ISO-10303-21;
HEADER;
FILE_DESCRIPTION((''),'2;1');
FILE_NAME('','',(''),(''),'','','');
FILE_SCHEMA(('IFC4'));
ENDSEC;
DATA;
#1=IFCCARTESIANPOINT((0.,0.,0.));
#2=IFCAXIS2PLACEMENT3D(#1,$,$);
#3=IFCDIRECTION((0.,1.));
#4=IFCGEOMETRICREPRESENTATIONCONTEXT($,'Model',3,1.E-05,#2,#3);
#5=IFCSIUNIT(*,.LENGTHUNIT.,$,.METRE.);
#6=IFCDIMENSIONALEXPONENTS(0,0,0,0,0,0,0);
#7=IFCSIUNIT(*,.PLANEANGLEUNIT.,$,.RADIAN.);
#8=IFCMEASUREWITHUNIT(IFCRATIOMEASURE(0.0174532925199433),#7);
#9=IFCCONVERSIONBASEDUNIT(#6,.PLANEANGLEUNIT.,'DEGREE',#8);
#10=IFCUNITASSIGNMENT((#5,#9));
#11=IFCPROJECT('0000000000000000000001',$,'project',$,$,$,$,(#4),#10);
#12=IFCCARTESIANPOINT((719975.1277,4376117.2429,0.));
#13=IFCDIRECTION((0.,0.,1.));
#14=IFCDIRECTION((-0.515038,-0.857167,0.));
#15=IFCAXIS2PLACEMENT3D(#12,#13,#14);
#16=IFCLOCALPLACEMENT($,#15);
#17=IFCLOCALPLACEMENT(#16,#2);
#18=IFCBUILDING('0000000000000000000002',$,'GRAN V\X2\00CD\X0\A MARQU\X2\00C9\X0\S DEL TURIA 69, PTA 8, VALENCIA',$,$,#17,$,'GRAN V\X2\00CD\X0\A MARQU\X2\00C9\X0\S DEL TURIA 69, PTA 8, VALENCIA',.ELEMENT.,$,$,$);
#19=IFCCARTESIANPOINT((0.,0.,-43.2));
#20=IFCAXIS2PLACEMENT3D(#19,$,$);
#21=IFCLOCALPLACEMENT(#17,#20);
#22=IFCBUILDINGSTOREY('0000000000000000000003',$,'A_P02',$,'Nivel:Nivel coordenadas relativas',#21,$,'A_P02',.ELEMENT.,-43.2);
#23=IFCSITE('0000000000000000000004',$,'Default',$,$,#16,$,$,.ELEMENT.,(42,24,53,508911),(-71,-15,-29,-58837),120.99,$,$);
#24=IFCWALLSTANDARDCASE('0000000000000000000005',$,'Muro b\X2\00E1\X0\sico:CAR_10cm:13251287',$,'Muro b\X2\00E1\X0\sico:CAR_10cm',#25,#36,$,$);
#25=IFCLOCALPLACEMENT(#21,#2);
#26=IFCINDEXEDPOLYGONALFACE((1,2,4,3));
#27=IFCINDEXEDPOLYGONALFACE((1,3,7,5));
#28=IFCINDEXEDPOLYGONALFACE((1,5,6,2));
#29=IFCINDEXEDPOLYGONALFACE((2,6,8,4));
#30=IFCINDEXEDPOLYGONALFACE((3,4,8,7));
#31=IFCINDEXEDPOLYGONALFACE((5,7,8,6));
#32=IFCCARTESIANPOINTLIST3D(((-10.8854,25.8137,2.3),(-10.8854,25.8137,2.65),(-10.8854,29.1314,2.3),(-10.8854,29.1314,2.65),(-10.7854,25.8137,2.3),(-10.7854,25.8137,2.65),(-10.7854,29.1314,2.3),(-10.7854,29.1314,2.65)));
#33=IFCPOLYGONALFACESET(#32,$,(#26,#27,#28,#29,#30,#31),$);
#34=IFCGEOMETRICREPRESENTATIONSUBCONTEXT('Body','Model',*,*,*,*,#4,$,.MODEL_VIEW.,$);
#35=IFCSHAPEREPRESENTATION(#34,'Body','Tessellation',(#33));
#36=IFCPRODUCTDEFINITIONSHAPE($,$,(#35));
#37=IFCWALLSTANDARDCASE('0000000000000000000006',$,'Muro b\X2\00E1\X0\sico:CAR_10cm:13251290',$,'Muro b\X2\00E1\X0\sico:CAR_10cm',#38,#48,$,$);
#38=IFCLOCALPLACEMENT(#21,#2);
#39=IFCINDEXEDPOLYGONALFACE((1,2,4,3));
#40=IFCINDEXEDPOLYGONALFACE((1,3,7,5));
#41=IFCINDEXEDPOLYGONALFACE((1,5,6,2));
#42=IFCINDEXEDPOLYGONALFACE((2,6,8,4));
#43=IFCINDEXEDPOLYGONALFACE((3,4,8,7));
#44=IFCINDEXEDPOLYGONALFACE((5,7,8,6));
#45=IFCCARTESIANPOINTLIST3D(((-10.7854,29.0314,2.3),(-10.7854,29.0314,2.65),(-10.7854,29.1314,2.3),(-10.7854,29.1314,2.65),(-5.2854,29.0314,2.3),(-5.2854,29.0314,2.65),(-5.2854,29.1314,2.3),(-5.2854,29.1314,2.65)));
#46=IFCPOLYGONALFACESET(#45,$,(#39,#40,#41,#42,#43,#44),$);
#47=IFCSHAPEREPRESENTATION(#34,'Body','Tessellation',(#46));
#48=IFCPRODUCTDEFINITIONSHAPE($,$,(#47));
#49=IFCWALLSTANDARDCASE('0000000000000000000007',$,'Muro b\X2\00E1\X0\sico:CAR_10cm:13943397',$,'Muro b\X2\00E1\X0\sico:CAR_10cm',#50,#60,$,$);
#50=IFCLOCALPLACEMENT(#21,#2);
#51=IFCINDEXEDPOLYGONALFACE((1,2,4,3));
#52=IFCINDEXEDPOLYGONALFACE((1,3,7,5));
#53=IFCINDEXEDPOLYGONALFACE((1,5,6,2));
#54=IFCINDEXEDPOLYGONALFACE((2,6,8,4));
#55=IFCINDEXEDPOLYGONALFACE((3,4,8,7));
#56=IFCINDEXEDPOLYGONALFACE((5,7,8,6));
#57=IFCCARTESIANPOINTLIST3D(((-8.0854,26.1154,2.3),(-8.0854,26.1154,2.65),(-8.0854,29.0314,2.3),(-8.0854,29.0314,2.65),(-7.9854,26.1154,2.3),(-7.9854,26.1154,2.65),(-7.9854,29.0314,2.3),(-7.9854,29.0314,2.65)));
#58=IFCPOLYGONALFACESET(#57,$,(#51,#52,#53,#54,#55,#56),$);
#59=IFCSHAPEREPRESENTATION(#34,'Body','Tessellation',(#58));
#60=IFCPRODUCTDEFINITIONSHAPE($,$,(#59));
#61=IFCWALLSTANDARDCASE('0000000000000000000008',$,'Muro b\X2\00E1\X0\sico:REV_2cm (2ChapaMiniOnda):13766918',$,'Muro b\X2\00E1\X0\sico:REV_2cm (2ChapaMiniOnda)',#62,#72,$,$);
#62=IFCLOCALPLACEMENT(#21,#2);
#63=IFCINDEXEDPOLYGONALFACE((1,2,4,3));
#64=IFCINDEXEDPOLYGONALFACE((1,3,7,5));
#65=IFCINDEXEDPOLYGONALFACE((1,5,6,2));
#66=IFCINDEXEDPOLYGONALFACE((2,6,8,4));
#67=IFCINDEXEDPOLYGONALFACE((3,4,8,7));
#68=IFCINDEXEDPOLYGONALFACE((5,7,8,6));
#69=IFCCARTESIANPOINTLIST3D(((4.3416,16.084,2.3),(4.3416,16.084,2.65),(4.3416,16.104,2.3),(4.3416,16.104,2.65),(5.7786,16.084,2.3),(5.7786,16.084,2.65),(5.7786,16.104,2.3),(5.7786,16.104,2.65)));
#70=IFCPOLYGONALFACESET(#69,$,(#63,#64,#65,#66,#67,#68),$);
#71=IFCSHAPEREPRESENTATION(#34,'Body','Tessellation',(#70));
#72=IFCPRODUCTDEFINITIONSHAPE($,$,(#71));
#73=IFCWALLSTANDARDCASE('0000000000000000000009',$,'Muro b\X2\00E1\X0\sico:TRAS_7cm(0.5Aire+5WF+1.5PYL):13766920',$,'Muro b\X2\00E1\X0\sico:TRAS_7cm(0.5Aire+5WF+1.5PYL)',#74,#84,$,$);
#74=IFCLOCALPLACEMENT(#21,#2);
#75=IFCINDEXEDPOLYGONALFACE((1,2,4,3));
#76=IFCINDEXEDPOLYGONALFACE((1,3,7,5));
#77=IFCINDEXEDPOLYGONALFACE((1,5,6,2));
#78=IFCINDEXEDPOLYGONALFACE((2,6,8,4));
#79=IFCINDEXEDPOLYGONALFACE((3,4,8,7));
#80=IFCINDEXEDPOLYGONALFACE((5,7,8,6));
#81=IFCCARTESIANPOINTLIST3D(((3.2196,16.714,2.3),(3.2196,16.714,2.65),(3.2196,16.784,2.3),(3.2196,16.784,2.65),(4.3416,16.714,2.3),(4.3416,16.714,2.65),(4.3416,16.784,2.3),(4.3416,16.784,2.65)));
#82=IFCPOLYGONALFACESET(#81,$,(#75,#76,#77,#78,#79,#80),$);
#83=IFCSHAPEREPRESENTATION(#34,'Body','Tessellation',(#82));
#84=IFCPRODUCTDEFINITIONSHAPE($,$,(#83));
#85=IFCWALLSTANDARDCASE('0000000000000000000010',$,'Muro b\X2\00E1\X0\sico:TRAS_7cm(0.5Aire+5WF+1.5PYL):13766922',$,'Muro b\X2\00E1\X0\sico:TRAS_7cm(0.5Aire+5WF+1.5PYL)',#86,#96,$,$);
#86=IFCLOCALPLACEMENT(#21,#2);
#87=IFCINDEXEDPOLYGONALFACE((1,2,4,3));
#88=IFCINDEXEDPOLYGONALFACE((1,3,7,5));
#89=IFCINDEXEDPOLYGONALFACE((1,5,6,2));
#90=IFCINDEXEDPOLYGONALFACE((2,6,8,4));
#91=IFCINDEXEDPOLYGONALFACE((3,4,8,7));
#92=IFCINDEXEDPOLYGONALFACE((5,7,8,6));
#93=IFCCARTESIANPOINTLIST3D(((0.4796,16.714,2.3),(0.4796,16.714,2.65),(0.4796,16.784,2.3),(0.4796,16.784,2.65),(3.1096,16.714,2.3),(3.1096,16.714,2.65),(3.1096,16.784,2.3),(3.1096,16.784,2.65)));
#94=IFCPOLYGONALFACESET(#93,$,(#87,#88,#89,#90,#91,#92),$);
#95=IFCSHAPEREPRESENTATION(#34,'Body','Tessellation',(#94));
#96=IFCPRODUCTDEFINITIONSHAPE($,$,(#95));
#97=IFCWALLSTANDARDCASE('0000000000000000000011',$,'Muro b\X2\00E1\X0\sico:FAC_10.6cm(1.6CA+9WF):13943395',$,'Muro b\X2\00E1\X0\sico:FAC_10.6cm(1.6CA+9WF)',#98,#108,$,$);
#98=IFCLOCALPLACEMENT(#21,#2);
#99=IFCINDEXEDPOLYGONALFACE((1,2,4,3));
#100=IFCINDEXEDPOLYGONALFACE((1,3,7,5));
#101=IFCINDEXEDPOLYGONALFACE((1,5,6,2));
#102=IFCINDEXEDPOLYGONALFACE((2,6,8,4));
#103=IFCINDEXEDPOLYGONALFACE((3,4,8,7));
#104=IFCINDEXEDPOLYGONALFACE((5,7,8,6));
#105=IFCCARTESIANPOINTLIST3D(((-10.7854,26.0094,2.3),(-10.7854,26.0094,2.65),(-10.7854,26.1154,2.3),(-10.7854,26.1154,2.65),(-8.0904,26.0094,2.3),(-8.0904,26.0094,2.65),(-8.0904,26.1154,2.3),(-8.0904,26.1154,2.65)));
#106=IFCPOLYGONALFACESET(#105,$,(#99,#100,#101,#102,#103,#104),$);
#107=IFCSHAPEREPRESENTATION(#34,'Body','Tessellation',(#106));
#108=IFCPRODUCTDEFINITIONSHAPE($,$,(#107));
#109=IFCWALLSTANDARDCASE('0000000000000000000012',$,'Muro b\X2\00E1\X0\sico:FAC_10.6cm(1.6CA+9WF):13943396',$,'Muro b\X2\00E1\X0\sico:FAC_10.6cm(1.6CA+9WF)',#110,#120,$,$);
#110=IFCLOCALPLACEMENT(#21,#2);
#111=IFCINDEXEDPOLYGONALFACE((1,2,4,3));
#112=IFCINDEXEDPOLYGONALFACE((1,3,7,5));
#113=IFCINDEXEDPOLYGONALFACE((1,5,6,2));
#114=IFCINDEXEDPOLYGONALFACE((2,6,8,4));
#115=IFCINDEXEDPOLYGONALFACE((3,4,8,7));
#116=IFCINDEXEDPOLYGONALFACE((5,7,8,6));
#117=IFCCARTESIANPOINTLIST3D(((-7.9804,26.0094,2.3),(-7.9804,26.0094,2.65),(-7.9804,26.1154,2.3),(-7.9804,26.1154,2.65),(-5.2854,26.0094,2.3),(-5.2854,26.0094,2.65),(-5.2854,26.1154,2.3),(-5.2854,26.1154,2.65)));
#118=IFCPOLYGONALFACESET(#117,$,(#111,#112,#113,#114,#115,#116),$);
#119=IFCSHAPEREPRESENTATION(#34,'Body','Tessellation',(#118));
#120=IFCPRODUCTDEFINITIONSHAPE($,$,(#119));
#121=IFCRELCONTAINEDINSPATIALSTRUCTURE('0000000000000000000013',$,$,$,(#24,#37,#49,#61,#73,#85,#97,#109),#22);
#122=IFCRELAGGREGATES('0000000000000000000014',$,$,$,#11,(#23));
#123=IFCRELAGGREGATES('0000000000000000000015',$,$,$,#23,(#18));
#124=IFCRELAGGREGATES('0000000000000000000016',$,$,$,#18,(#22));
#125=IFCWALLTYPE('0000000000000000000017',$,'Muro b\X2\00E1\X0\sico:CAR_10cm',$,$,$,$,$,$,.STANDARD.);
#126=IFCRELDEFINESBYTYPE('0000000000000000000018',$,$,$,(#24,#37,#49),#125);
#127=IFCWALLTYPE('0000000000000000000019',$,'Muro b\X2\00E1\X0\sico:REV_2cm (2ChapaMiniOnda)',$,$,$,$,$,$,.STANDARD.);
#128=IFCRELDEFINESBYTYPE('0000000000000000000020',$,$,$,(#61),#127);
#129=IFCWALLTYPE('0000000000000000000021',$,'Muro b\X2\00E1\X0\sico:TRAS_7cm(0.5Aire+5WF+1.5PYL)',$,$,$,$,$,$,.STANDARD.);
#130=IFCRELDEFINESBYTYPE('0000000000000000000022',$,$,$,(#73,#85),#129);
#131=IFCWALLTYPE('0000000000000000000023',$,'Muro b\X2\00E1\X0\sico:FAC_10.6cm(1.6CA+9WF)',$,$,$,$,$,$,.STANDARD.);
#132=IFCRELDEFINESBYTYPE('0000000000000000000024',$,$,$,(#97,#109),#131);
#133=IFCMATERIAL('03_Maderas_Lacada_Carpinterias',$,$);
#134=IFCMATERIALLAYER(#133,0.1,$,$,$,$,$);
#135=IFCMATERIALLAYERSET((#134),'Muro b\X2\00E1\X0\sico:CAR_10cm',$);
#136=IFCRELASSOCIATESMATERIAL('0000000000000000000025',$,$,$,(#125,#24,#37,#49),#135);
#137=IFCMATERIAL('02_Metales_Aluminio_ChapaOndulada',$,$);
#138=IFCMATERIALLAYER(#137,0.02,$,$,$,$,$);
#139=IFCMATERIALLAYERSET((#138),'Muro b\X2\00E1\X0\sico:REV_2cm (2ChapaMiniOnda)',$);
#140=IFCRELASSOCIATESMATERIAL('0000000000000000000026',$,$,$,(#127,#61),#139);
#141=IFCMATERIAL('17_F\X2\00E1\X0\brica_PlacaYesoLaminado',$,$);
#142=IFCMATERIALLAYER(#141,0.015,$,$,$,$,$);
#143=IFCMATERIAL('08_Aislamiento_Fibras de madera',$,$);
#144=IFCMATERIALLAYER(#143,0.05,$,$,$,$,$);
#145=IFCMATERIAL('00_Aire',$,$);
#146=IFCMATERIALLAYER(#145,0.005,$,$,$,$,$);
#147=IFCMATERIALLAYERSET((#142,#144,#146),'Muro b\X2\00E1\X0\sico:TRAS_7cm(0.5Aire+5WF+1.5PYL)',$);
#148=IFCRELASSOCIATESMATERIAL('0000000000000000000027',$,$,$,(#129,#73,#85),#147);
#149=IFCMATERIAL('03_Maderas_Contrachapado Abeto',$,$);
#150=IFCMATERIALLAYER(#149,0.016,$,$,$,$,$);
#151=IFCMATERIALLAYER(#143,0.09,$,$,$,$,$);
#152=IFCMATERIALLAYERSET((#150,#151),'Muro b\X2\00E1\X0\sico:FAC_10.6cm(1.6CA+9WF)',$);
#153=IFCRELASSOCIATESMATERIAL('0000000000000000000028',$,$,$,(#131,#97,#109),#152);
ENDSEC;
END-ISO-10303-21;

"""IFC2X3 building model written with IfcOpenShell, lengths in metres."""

from ifc_helpers import new_model, entity, si_unit, converted_unit, direction, frame, frame_2d, origin, place, context, subcontext, project, spatial, rectangle, extrude, material, layer, layer_set, layer_usage, type_object, element, save


model = new_model("IFC2X3")

# Units and contexts
model_context = context("Model", 3, precision=1e-05, world=origin(), true_north=direction((0.0, 1.0)))
body_context = subcontext(model_context, "Body", "Model", "MODEL_VIEW")
ifc_project = project(units=[si_unit("LENGTHUNIT", "METRE"), converted_unit("PLANEANGLEUNIT", "DEGREE", entity("IfcRatioMeasure", 0.0174532925199433), si_unit("PLANEANGLEUNIT", "RADIAN"), dimensions=[0, 0, 0, 0, 0, 0, 0])], contexts=[model_context])

# Site, building, storey
site_placement = place(None, frame((719975.1277, 4376117.2429, 0.0), z_axis=(0.0, 0.0, 1.0), x_axis=(-0.515038, -0.857167, 0.0)))
site = spatial("IfcSite", under=ifc_project, at=site_placement, Name="Default", CompositionType="ELEMENT", RefLatitude=(42, 24, 53, 508911), RefLongitude=(-71, -15, -29, -58837), RefElevation=120.99)
building_placement = place(site_placement, origin())
building = spatial("IfcBuilding", under=site, at=building_placement, Name="GRAN VÍA MARQUÉS DEL TURIA 69, PTA 8, VALENCIA", LongName="GRAN VÍA MARQUÉS DEL TURIA 69, PTA 8, VALENCIA", CompositionType="ELEMENT")
storey_placement = place(building_placement, frame((0.0, 0.0, -43.2)))
storey = spatial("IfcBuildingStorey", under=building, at=storey_placement, Name="A_P02", ObjectType="Nivel:Nivel coordenadas relativas", LongName="A_P02", CompositionType="ELEMENT", Elevation=-43.2)

# Shared definitions
ifc_material_1 = material(Name="03_Maderas_Lacada_Carpinterias")

# Walls
ifc_layer_1 = layer(ifc_material_1, 0.1)
ifc_layer_set_1 = layer_set([ifc_layer_1], Name="Muro básico:CAR_10cm")
wall_type_1 = type_object("IfcWallType", Name="Muro básico:CAR_10cm", PredefinedType="STANDARD", material=ifc_layer_set_1)
ifc_layer_usage_1 = layer_usage(ifc_layer_set_1, "AXIS2", "NEGATIVE", 0.05)
wall_1_placement = place(storey_placement, frame((-10.8354, 25.8137, 2.3), z_axis=(0.0, 0.0, 1.0), x_axis=(0.0, 1.0, 0.0)))
element("IfcWallStandardCase", 1, at=wall_1_placement, inside=storey, type_object=wall_type_1, material=ifc_layer_usage_1, Name="Muro básico:CAR_10cm:13251287", ObjectType="Muro básico:CAR_10cm", context=body_context, shape_type="SweptSolid", body=[
    extrude(rectangle(XDim=3.3177, YDim=0.1, at=frame_2d((1.6588, 0.0), x_axis=(-1.0, 0.0))), origin(), (0.0, 0.0, 1.0), 0.35),
])
ifc_layer_usage_2 = layer_usage(ifc_layer_set_1, "AXIS2", "NEGATIVE", 0.05)
wall_2_placement = place(storey_placement, frame((-5.2854, 29.0814, 2.3), z_axis=(0.0, 0.0, 1.0), x_axis=(-1.0, 0.0, 0.0)))
element("IfcWallStandardCase", 2, at=wall_2_placement, inside=storey, type_object=wall_type_1, material=ifc_layer_usage_2, Name="Muro básico:CAR_10cm:13251290", ObjectType="Muro básico:CAR_10cm", context=body_context, shape_type="SweptSolid", body=[
    extrude(rectangle(XDim=5.5, YDim=0.1, at=frame_2d((2.75, 0.0), x_axis=(-1.0, 0.0))), origin(), (0.0, 0.0, 1.0), 0.35),
])
ifc_layer_usage_3 = layer_usage(ifc_layer_set_1, "AXIS2", "NEGATIVE", 0.05)
wall_3_placement = place(storey_placement, frame((-8.0354, 26.1154, 2.3), z_axis=(0.0, 0.0, 1.0), x_axis=(0.0, 1.0, 0.0)))
element("IfcWallStandardCase", 3, at=wall_3_placement, inside=storey, type_object=wall_type_1, material=ifc_layer_usage_3, Name="Muro básico:CAR_10cm:13943397", ObjectType="Muro básico:CAR_10cm", context=body_context, shape_type="SweptSolid", body=[
    extrude(rectangle(XDim=2.916, YDim=0.1, at=frame_2d((1.458, 0.0), x_axis=(-1.0, 0.0))), origin(), (0.0, 0.0, 1.0), 0.35),
])
ifc_material_2 = material(Name="02_Metales_Aluminio_ChapaOndulada")
ifc_layer_2 = layer(ifc_material_2, 0.02)
ifc_layer_set_2 = layer_set([ifc_layer_2], Name="Muro básico:REV_2cm (2ChapaMiniOnda)")
ifc_layer_usage_4 = layer_usage(ifc_layer_set_2, "AXIS2", "NEGATIVE", 0.01)
wall_type_2 = type_object("IfcWallType", Name="Muro básico:REV_2cm (2ChapaMiniOnda)", PredefinedType="STANDARD", material=ifc_layer_set_2)
wall_4_placement = place(storey_placement, frame((4.3416, 16.094, 2.3)))
element("IfcWallStandardCase", 4, at=wall_4_placement, inside=storey, type_object=wall_type_2, material=ifc_layer_usage_4, Name="Muro básico:REV_2cm (2ChapaMiniOnda):13766918", ObjectType="Muro básico:REV_2cm (2ChapaMiniOnda)", context=body_context, shape_type="SweptSolid", body=[
    extrude(rectangle(XDim=1.437, YDim=0.02, at=frame_2d((0.7185, 0.0), x_axis=(-1.0, 0.0))), origin(), (0.0, 0.0, 1.0), 0.35),
])
ifc_material_3 = material(Name="17_Fábrica_PlacaYesoLaminado")
ifc_layer_3 = layer(ifc_material_3, 0.015)
ifc_material_4 = material(Name="08_Aislamiento_Fibras de madera")
ifc_layer_4 = layer(ifc_material_4, 0.05)
ifc_material_5 = material(Name="00_Aire")
ifc_layer_5 = layer(ifc_material_5, 0.005)
ifc_layer_set_3 = layer_set([ifc_layer_3, ifc_layer_4, ifc_layer_5], Name="Muro básico:TRAS_7cm(0.5Aire+5WF+1.5PYL)")
ifc_layer_usage_5 = layer_usage(ifc_layer_set_3, "AXIS2", "NEGATIVE", 0.035)
wall_type_3 = type_object("IfcWallType", Name="Muro básico:TRAS_7cm(0.5Aire+5WF+1.5PYL)", PredefinedType="STANDARD", material=ifc_layer_set_3)
wall_5_placement = place(storey_placement, frame((3.2196, 16.749, 2.3)))
element("IfcWallStandardCase", 5, at=wall_5_placement, inside=storey, type_object=wall_type_3, material=ifc_layer_usage_5, Name="Muro básico:TRAS_7cm(0.5Aire+5WF+1.5PYL):13766920", ObjectType="Muro básico:TRAS_7cm(0.5Aire+5WF+1.5PYL)", context=body_context, shape_type="SweptSolid", body=[
    extrude(rectangle(XDim=1.122, YDim=0.07, at=frame_2d((0.561, 0.0), x_axis=(-1.0, 0.0))), origin(), (0.0, 0.0, 1.0), 0.35),
])
ifc_layer_usage_6 = layer_usage(ifc_layer_set_3, "AXIS2", "NEGATIVE", 0.035)
wall_6_placement = place(storey_placement, frame((0.4796, 16.749, 2.3)))
element("IfcWallStandardCase", 6, at=wall_6_placement, inside=storey, type_object=wall_type_3, material=ifc_layer_usage_6, Name="Muro básico:TRAS_7cm(0.5Aire+5WF+1.5PYL):13766922", ObjectType="Muro básico:TRAS_7cm(0.5Aire+5WF+1.5PYL)", context=body_context, shape_type="SweptSolid", body=[
    extrude(rectangle(XDim=2.63, YDim=0.07, at=frame_2d((1.315, 0.0), x_axis=(-1.0, 0.0))), origin(), (0.0, 0.0, 1.0), 0.35),
])
ifc_material_6 = material(Name="03_Maderas_Contrachapado Abeto")
ifc_layer_6 = layer(ifc_material_6, 0.016)
ifc_layer_7 = layer(ifc_material_4, 0.09)
ifc_layer_set_4 = layer_set([ifc_layer_6, ifc_layer_7], Name="Muro básico:FAC_10.6cm(1.6CA+9WF)")
ifc_layer_usage_7 = layer_usage(ifc_layer_set_4, "AXIS2", "NEGATIVE", 0.053)
wall_type_4 = type_object("IfcWallType", Name="Muro básico:FAC_10.6cm(1.6CA+9WF)", PredefinedType="STANDARD", material=ifc_layer_set_4)
wall_7_placement = place(storey_placement, frame((-10.7854, 26.0624, 2.3)))
element("IfcWallStandardCase", 7, at=wall_7_placement, inside=storey, type_object=wall_type_4, material=ifc_layer_usage_7, Name="Muro básico:FAC_10.6cm(1.6CA+9WF):13943395", ObjectType="Muro básico:FAC_10.6cm(1.6CA+9WF)", context=body_context, shape_type="SweptSolid", body=[
    extrude(rectangle(XDim=2.695, YDim=0.106, at=frame_2d((1.3475, 0.0), x_axis=(-1.0, 0.0))), origin(), (0.0, 0.0, 1.0), 0.35),
])
ifc_layer_usage_8 = layer_usage(ifc_layer_set_4, "AXIS2", "NEGATIVE", 0.053)
wall_8_placement = place(storey_placement, frame((-7.9804, 26.0624, 2.3)))
element("IfcWallStandardCase", 8, at=wall_8_placement, inside=storey, type_object=wall_type_4, material=ifc_layer_usage_8, Name="Muro básico:FAC_10.6cm(1.6CA+9WF):13943396", ObjectType="Muro básico:FAC_10.6cm(1.6CA+9WF)", context=body_context, shape_type="SweptSolid", body=[
    extrude(rectangle(XDim=2.695, YDim=0.106, at=frame_2d((1.3475, 0.0), x_axis=(-1.0, 0.0))), origin(), (0.0, 0.0, 1.0), 0.35),
])

save(model, "model.ifc")
